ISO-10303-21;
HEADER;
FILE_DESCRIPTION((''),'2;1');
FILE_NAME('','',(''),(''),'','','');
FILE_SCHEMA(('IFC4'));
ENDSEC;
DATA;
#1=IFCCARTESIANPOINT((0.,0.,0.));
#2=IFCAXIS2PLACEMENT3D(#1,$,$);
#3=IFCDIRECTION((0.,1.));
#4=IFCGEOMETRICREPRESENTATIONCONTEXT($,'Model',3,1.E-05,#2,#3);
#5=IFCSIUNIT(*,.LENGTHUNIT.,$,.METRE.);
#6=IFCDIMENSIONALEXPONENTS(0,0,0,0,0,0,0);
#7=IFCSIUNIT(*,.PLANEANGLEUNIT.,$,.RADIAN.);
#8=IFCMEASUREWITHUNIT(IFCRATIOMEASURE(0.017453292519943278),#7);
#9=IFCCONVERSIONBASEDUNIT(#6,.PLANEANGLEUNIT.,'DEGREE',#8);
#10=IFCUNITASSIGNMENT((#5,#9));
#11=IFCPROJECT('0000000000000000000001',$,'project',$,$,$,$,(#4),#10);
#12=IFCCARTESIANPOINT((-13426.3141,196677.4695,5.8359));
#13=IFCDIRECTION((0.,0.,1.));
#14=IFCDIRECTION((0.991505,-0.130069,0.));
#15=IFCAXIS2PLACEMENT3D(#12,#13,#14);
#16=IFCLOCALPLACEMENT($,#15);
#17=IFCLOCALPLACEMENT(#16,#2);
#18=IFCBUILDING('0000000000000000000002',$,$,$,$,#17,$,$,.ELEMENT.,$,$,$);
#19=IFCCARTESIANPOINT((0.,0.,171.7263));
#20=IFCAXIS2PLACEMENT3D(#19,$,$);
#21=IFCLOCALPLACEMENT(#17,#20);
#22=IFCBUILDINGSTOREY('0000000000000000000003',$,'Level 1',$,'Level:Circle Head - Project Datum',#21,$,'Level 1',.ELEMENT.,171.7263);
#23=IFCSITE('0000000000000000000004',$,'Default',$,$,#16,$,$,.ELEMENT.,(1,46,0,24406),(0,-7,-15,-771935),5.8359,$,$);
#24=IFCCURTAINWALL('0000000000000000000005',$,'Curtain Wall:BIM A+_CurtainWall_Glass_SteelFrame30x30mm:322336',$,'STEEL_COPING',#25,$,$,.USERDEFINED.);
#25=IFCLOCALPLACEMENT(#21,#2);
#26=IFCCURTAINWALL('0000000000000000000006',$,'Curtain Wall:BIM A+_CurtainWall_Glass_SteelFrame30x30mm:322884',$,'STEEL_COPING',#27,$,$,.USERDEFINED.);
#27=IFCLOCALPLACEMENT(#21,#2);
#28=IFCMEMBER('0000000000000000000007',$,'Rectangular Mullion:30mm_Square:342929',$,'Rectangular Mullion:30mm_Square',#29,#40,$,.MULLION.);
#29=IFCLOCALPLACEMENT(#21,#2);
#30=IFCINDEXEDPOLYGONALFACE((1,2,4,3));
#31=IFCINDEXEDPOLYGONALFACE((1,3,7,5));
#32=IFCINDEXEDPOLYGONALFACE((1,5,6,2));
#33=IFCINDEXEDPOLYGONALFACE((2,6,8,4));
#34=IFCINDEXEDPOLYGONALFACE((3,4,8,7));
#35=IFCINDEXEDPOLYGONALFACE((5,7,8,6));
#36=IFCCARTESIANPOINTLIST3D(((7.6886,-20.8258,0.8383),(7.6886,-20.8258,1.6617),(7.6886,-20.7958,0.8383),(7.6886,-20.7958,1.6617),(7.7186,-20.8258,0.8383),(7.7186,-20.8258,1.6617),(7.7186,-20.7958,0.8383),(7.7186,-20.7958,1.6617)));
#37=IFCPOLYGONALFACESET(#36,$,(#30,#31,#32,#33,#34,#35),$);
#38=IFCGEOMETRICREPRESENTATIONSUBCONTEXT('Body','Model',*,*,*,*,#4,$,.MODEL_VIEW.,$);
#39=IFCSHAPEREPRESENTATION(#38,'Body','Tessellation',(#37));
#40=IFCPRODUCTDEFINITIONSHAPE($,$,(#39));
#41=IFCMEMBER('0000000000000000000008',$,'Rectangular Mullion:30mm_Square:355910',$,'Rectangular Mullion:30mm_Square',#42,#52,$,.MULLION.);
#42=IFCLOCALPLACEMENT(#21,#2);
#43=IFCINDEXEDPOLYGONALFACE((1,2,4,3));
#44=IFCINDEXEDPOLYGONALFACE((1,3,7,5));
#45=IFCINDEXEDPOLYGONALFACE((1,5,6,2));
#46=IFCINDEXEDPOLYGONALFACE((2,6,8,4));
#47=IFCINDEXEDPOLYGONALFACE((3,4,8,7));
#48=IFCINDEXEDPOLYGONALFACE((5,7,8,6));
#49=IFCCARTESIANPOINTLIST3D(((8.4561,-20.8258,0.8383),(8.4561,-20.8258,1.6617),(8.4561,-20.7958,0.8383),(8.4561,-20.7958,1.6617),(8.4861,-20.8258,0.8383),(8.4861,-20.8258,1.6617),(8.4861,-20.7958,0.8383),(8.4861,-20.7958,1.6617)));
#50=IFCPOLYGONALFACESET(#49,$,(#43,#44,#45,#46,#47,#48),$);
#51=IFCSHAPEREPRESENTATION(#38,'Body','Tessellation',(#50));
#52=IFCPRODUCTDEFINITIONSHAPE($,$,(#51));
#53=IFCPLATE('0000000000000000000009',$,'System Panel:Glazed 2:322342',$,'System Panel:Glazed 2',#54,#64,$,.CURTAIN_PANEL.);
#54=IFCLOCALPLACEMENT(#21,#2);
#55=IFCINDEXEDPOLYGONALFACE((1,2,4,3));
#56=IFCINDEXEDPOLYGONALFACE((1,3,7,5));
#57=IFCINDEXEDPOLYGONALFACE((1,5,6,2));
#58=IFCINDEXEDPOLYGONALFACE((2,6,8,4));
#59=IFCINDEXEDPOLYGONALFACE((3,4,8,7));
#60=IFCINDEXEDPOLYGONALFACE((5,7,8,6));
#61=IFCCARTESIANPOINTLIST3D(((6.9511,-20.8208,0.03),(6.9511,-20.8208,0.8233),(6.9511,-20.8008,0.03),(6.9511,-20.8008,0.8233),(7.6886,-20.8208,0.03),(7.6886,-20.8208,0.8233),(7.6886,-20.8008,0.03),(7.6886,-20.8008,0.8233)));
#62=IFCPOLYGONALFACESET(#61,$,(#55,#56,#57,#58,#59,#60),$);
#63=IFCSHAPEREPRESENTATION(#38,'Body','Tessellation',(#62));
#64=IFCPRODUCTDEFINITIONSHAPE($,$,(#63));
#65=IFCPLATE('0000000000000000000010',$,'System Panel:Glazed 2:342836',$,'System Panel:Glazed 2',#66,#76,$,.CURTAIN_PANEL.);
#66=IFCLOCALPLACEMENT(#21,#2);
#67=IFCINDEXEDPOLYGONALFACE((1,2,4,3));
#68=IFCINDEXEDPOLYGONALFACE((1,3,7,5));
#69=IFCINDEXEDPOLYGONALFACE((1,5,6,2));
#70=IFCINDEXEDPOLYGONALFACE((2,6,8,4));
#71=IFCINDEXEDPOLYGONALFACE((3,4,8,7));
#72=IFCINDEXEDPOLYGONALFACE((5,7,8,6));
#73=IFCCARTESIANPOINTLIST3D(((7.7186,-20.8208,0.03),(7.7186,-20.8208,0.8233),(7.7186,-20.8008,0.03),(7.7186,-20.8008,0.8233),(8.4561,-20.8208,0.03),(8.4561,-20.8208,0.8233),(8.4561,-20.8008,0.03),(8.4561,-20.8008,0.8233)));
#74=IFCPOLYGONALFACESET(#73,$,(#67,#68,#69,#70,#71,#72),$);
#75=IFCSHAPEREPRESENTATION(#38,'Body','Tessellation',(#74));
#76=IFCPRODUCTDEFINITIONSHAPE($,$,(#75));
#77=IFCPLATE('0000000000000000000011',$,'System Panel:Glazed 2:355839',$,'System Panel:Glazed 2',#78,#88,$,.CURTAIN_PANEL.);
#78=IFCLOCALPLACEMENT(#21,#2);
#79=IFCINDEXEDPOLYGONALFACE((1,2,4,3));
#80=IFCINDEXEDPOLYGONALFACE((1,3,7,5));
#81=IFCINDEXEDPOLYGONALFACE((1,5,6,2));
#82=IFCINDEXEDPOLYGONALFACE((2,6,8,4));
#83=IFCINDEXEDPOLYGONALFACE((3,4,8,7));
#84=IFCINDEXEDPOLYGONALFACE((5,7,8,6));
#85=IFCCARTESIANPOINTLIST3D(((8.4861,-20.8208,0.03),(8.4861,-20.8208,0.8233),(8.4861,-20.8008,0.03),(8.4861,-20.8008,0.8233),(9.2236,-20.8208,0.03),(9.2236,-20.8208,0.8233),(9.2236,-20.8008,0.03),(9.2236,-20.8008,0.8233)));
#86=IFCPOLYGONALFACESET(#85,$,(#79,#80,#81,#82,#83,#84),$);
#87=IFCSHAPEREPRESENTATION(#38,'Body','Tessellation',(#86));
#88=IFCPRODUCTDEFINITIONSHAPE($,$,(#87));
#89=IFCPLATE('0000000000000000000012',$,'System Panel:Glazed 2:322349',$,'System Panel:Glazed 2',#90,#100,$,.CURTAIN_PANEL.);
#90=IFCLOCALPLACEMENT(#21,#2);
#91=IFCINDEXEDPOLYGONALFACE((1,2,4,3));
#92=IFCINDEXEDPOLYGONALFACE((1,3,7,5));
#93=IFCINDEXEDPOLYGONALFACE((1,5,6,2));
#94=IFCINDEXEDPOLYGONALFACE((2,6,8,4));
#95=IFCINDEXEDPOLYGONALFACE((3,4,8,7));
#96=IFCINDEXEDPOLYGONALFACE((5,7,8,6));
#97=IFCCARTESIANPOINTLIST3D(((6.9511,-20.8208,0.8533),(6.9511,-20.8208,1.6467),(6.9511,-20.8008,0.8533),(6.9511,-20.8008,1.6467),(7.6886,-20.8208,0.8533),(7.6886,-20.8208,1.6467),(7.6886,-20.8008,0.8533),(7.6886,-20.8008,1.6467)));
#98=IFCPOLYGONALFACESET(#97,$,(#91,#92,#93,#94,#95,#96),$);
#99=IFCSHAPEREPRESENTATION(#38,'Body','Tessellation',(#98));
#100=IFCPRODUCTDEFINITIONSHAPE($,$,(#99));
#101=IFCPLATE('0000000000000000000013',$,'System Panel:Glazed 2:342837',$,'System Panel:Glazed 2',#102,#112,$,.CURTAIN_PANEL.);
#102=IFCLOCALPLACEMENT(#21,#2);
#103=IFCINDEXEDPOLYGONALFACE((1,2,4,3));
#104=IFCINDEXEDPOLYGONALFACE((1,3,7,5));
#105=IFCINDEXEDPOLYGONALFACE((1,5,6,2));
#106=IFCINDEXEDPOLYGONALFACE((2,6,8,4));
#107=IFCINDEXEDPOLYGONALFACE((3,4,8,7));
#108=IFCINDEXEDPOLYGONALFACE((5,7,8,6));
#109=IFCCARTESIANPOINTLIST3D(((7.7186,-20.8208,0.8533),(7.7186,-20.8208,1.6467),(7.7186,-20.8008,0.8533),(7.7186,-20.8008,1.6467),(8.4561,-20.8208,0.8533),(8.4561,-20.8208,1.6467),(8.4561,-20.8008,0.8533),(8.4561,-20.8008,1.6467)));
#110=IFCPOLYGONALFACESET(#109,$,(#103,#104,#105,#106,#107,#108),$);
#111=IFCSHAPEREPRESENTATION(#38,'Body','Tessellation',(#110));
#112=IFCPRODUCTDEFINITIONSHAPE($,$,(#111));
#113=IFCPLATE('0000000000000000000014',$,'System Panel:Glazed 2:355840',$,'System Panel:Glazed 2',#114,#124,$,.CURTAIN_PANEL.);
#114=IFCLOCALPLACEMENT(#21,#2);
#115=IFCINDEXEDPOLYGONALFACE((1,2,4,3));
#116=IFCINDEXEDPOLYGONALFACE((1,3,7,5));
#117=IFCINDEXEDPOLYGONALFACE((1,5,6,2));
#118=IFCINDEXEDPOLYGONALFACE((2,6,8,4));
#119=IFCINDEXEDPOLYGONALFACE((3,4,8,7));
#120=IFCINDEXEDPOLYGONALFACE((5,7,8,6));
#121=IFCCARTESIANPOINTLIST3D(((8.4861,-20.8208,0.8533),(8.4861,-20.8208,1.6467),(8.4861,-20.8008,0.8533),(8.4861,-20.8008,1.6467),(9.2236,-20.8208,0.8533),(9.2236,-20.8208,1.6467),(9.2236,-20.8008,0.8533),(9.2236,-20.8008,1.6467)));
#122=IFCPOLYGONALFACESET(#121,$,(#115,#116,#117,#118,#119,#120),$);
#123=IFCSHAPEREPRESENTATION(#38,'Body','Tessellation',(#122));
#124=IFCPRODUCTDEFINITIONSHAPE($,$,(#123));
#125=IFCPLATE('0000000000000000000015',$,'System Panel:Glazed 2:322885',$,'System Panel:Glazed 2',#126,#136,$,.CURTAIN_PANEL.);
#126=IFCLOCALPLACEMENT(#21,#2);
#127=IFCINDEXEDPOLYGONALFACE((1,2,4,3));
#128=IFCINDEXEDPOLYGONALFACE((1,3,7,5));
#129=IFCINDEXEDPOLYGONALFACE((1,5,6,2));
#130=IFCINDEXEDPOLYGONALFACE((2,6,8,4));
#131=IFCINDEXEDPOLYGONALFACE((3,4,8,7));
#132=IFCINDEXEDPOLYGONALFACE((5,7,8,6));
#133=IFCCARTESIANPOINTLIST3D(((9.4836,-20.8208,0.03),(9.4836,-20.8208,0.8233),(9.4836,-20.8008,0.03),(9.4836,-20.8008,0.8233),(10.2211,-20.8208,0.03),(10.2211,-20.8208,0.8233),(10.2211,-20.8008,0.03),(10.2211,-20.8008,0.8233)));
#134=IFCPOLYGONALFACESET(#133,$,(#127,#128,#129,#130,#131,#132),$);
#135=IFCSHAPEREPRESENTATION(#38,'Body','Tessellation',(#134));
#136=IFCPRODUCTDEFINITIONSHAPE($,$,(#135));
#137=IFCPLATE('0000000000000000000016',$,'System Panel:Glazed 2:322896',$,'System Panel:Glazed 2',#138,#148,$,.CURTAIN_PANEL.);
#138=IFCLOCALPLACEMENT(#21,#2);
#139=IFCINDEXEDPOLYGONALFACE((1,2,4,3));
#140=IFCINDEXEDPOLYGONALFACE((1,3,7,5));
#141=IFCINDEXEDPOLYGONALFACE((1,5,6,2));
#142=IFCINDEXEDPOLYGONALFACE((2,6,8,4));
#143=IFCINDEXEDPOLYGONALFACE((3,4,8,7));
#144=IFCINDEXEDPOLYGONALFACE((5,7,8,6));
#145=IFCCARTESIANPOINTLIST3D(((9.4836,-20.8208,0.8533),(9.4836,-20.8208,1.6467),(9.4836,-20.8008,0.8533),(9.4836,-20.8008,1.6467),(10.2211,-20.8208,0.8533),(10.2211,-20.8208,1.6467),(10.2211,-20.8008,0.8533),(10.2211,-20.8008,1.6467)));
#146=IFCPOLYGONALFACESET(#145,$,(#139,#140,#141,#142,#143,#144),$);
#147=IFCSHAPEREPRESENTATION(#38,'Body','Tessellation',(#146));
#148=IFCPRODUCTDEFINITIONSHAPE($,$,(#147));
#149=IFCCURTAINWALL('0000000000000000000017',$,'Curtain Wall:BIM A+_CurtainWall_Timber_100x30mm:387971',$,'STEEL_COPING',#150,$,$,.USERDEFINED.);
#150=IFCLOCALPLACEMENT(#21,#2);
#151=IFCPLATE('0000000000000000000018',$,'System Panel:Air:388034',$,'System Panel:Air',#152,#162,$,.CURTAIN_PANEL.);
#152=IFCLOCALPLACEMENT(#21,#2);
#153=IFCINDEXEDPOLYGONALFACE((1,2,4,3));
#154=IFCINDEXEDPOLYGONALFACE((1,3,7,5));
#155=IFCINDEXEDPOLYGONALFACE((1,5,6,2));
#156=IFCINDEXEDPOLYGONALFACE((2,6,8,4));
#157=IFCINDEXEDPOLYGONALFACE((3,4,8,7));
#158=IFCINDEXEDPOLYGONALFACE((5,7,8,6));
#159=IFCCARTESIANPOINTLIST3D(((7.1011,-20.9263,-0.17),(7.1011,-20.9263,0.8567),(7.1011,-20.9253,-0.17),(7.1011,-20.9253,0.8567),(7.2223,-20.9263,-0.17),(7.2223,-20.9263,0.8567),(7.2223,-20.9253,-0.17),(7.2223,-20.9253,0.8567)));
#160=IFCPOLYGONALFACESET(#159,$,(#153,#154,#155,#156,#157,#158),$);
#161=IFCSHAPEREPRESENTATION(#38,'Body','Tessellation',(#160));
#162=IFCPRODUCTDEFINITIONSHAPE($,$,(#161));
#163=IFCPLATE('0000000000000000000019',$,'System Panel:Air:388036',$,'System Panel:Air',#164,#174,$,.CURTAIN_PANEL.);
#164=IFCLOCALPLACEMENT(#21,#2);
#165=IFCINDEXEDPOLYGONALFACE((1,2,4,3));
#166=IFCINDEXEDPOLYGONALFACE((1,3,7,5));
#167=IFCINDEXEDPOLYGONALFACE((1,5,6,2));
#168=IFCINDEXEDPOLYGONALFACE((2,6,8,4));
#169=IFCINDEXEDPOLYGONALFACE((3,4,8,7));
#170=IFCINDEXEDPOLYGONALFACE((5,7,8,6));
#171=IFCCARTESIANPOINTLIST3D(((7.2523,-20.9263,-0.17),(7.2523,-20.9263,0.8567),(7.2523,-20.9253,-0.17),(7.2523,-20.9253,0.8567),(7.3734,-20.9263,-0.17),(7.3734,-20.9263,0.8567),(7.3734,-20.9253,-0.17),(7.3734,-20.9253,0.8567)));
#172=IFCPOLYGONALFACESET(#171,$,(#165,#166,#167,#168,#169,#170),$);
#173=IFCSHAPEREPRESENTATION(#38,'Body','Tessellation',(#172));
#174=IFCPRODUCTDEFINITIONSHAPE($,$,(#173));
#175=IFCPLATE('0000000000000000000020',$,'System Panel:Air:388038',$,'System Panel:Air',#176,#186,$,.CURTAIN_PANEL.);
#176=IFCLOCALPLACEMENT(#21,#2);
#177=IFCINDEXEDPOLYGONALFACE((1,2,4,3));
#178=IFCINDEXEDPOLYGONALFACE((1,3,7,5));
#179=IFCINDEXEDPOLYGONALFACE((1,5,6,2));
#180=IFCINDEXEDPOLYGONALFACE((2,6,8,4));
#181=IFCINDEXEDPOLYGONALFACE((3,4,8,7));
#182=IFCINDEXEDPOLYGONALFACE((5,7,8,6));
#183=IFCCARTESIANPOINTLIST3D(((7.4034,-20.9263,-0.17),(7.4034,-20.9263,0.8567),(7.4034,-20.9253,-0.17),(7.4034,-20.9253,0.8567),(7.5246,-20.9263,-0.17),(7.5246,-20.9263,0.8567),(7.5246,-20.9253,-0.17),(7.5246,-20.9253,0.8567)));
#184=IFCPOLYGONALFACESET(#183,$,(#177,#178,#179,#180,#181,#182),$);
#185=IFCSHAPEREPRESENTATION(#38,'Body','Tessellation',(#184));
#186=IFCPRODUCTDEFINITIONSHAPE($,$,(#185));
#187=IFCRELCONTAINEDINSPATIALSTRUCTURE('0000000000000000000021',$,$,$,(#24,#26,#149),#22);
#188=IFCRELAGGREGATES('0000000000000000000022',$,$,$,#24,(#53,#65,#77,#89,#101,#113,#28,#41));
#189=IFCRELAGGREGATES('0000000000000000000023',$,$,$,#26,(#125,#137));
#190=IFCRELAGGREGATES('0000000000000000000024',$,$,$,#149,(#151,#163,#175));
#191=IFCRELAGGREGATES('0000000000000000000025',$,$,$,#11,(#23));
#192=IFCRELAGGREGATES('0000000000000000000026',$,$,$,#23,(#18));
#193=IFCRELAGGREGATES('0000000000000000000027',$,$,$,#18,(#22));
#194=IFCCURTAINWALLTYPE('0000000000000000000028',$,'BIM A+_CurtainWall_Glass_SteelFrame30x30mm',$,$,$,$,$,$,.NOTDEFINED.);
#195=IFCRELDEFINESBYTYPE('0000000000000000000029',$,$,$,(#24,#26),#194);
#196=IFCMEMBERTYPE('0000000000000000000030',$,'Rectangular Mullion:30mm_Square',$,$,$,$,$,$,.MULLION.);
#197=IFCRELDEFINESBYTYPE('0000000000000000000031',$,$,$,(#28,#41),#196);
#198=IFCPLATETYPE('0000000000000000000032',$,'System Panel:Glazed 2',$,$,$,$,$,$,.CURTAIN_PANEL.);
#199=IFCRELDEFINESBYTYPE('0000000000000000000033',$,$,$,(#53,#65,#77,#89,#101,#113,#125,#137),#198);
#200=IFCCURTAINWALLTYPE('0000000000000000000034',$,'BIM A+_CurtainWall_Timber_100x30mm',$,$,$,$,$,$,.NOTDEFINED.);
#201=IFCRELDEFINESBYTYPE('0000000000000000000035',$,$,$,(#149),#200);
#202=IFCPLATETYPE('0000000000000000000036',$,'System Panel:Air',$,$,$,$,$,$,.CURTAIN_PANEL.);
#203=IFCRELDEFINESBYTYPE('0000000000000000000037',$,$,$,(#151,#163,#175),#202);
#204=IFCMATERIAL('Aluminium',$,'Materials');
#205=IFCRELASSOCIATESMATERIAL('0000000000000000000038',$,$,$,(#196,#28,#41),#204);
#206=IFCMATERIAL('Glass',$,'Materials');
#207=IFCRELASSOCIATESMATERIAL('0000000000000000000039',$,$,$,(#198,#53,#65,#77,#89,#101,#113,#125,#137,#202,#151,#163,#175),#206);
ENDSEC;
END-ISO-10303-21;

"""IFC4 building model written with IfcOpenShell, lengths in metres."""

from ifc_helpers import new_model, entity, si_unit, converted_unit, direction, frame, origin, place, context, subcontext, project, spatial, indexed_curve, outline, extrude, source, transform, mapped, material, type_object, type_shapes, element, aggregate, save


model = new_model("IFC4")

# Units and contexts
model_context = context("Model", 3, precision=1e-05, world=origin(), true_north=direction((0.0, 1.0)))
body_context = subcontext(model_context, "Body", "Model", "MODEL_VIEW")
ifc_project = project(units=[si_unit("LENGTHUNIT", "METRE"), converted_unit("PLANEANGLEUNIT", "DEGREE", entity("IfcRatioMeasure", 0.017453292519943278), si_unit("PLANEANGLEUNIT", "RADIAN"), dimensions=[0, 0, 0, 0, 0, 0, 0])], contexts=[model_context])

# Site, building, storey
site_placement = place(None, frame((-13426.3141, 196677.4695, 5.8359), z_axis=(0.0, 0.0, 1.0), x_axis=(0.991505, -0.130069, 0.0)))
site = spatial("IfcSite", under=ifc_project, at=site_placement, Name="Default", CompositionType="ELEMENT", RefLatitude=(1, 46, 0, 24406), RefLongitude=(0, -7, -15, -771935), RefElevation=5.8359)
building_placement = place(site_placement, origin())
building = spatial("IfcBuilding", under=site, at=building_placement, CompositionType="ELEMENT")
storey_placement = place(building_placement, frame((0.0, 0.0, 171.7263)))
storey = spatial("IfcBuildingStorey", under=building, at=storey_placement, Name="Level 1", ObjectType="Level:Circle Head - Project Datum", LongName="Level 1", CompositionType="ELEMENT", Elevation=171.7263)

# Curtain wall
curtain_wall_type_1 = type_object("IfcCurtainWallType", Name="BIM A+_CurtainWall_Glass_SteelFrame30x30mm", PredefinedType="NOTDEFINED")
curtain_wall_1_placement = place(storey_placement, frame((0.0, 0.0, -171.7263)))
curtain_wall_1 = element("IfcCurtainWall", 1, at=curtain_wall_1_placement, inside=storey, type_object=curtain_wall_type_1, Name="Curtain Wall:BIM A+_CurtainWall_Glass_SteelFrame30x30mm:322336", ObjectType="STEEL_COPING", PredefinedType="USERDEFINED")
ifc_material_1 = material(Name="Aluminium", Category="Materials")

# Curtain wall
curtain_wall_2_placement = place(storey_placement, frame((0.0, 0.0, -171.7263)))
curtain_wall_2 = element("IfcCurtainWall", 2, at=curtain_wall_2_placement, inside=storey, type_object=curtain_wall_type_1, Name="Curtain Wall:BIM A+_CurtainWall_Glass_SteelFrame30x30mm:322884", ObjectType="STEEL_COPING", PredefinedType="USERDEFINED")

# Members
member_type_1 = type_object("IfcMemberType", Name="Rectangular Mullion:30mm_Square", PredefinedType="MULLION", material=ifc_material_1)
shared_shape_1 = source(origin(), body_context, "Body", "SweptSolid", [
    extrude(outline(indexed_curve([(-0.015, -0.015), (0.015, -0.015), (0.015, 0.015), (-0.015, 0.015), (-0.015, -0.015)], self_intersect=False)), frame((0.0, 0.0, -0.8233), z_axis=(0.0, 0.0, 1.0), x_axis=(0.0, -1.0, 0.0)), (0.0, 0.0, 1.0), 0.8233),
])
type_shapes(member_type_1, [shared_shape_1])
member_1_placement = place(curtain_wall_1_placement, frame((7.7036, -20.8108, 172.5646), z_axis=(0.0, 0.0, -1.0), x_axis=(1.0, 0.0, 0.0)))
member_1 = element("IfcMember", 3, at=member_1_placement, type_object=member_type_1, material=ifc_material_1, Name="Rectangular Mullion:30mm_Square:342929", ObjectType="Rectangular Mullion:30mm_Square", PredefinedType="MULLION", context=body_context, shape_type="MappedRepresentation", body=[
    mapped(shared_shape_1, transform((0.0, 0.0, 0.0), scale=1.0)),
])
member_2_placement = place(curtain_wall_1_placement, frame((8.4711, -20.8108, 172.5646), z_axis=(0.0, 0.0, -1.0), x_axis=(1.0, 0.0, 0.0)))
member_2 = element("IfcMember", 4, at=member_2_placement, type_object=member_type_1, material=ifc_material_1, Name="Rectangular Mullion:30mm_Square:355910", ObjectType="Rectangular Mullion:30mm_Square", PredefinedType="MULLION", context=body_context, shape_type="MappedRepresentation", body=[
    mapped(shared_shape_1, transform((0.0, 0.0, 0.0), scale=1.0)),
])

# Plates
ifc_material_2 = material(Name="Glass", Category="Materials")
plate_type_1 = type_object("IfcPlateType", Name="System Panel:Glazed 2", PredefinedType="CURTAIN_PANEL", material=ifc_material_2)
shared_shape_2 = source(origin(), body_context, "Body", "SweptSolid", [
    extrude(outline(indexed_curve([(-0.01, -0.3688), (0.01, -0.3688), (0.01, 0.3688), (-0.01, 0.3688), (-0.01, -0.3688)], self_intersect=False)), frame((0.0, 0.0, 0.0), z_axis=(0.0, 0.0, 1.0), x_axis=(0.0, 1.0, 0.0)), (0.0, 0.0, 1.0), 0.7933),
])
type_shapes(plate_type_1, [shared_shape_2])
plate_1_placement = place(curtain_wall_1_placement, frame((7.3198, -20.8108, 171.7563)))
plate_1 = element("IfcPlate", 5, at=plate_1_placement, type_object=plate_type_1, material=ifc_material_2, Name="System Panel:Glazed 2:322342", ObjectType="System Panel:Glazed 2", PredefinedType="CURTAIN_PANEL", context=body_context, shape_type="MappedRepresentation", body=[
    mapped(shared_shape_2, transform((0.0, 0.0, 0.0), scale=1.0)),
])
plate_2_placement = place(curtain_wall_1_placement, frame((8.0873, -20.8108, 171.7563)))
plate_2 = element("IfcPlate", 6, at=plate_2_placement, type_object=plate_type_1, material=ifc_material_2, Name="System Panel:Glazed 2:342836", ObjectType="System Panel:Glazed 2", PredefinedType="CURTAIN_PANEL", context=body_context, shape_type="MappedRepresentation", body=[
    mapped(shared_shape_2, transform((0.0, 0.0, 0.0), scale=1.0)),
])
plate_3_placement = place(curtain_wall_1_placement, frame((8.8548, -20.8108, 171.7563)))
plate_3 = element("IfcPlate", 7, at=plate_3_placement, type_object=plate_type_1, material=ifc_material_2, Name="System Panel:Glazed 2:355839", ObjectType="System Panel:Glazed 2", PredefinedType="CURTAIN_PANEL", context=body_context, shape_type="MappedRepresentation", body=[
    mapped(shared_shape_2, transform((0.0, 0.0, 0.0), scale=1.0)),
])
plate_4_placement = place(curtain_wall_1_placement, frame((7.3198, -20.8108, 172.5796)))
plate_4 = element("IfcPlate", 8, at=plate_4_placement, type_object=plate_type_1, material=ifc_material_2, Name="System Panel:Glazed 2:322349", ObjectType="System Panel:Glazed 2", PredefinedType="CURTAIN_PANEL", context=body_context, shape_type="MappedRepresentation", body=[
    mapped(shared_shape_2, transform((0.0, 0.0, 0.0), scale=1.0)),
])
plate_5_placement = place(curtain_wall_1_placement, frame((8.0873, -20.8108, 172.5796)))
plate_5 = element("IfcPlate", 9, at=plate_5_placement, type_object=plate_type_1, material=ifc_material_2, Name="System Panel:Glazed 2:342837", ObjectType="System Panel:Glazed 2", PredefinedType="CURTAIN_PANEL", context=body_context, shape_type="MappedRepresentation", body=[
    mapped(shared_shape_2, transform((0.0, 0.0, 0.0), scale=1.0)),
])
plate_6_placement = place(curtain_wall_1_placement, frame((8.8548, -20.8108, 172.5796)))
plate_6 = element("IfcPlate", 10, at=plate_6_placement, type_object=plate_type_1, material=ifc_material_2, Name="System Panel:Glazed 2:355840", ObjectType="System Panel:Glazed 2", PredefinedType="CURTAIN_PANEL", context=body_context, shape_type="MappedRepresentation", body=[
    mapped(shared_shape_2, transform((0.0, 0.0, 0.0), scale=1.0)),
])
aggregate(curtain_wall_1, [plate_1, plate_2, plate_3, plate_4, plate_5, plate_6, member_1, member_2])
plate_7_placement = place(curtain_wall_2_placement, frame((9.8523, -20.8108, 171.7563)))
plate_7 = element("IfcPlate", 11, at=plate_7_placement, type_object=plate_type_1, material=ifc_material_2, Name="System Panel:Glazed 2:322885", ObjectType="System Panel:Glazed 2", PredefinedType="CURTAIN_PANEL", context=body_context, shape_type="MappedRepresentation", body=[
    mapped(shared_shape_2, transform((0.0, 0.0, 0.0), scale=1.0)),
])
plate_8_placement = place(curtain_wall_2_placement, frame((9.8523, -20.8108, 172.5796)))
plate_8 = element("IfcPlate", 12, at=plate_8_placement, type_object=plate_type_1, material=ifc_material_2, Name="System Panel:Glazed 2:322896", ObjectType="System Panel:Glazed 2", PredefinedType="CURTAIN_PANEL", context=body_context, shape_type="MappedRepresentation", body=[
    mapped(shared_shape_2, transform((0.0, 0.0, 0.0), scale=1.0)),
])
aggregate(curtain_wall_2, [plate_7, plate_8])

# Curtain wall, plates
curtain_wall_type_2 = type_object("IfcCurtainWallType", Name="BIM A+_CurtainWall_Timber_100x30mm", PredefinedType="NOTDEFINED")
curtain_wall_3_placement = place(storey_placement, frame((0.0, 0.0, -171.7263)))
curtain_wall_3 = element("IfcCurtainWall", 13, at=curtain_wall_3_placement, inside=storey, type_object=curtain_wall_type_2, Name="Curtain Wall:BIM A+_CurtainWall_Timber_100x30mm:387971", ObjectType="STEEL_COPING", PredefinedType="USERDEFINED")
plate_type_2 = type_object("IfcPlateType", Name="System Panel:Air", PredefinedType="CURTAIN_PANEL", material=ifc_material_2)
shared_shape_3 = source(origin(), body_context, "Body", "SweptSolid", [
    extrude(outline(indexed_curve([(-0.0005, -0.0606), (0.0005, -0.0606), (0.0005, 0.0606), (-0.0005, 0.0606), (-0.0005, -0.0606)], self_intersect=False)), frame((0.0, 0.0, 0.0), z_axis=(0.0, 0.0, 1.0), x_axis=(0.0, 1.0, 0.0)), (0.0, 0.0, 1.0), 1.0267),
])
type_shapes(plate_type_2, [shared_shape_3])
plate_9_placement = place(curtain_wall_3_placement, frame((7.1617, -20.9258, 171.5563)))
plate_9 = element("IfcPlate", 14, at=plate_9_placement, type_object=plate_type_2, material=ifc_material_2, Name="System Panel:Air:388034", ObjectType="System Panel:Air", PredefinedType="CURTAIN_PANEL", context=body_context, shape_type="MappedRepresentation", body=[
    mapped(shared_shape_3, transform((0.0, 0.0, 0.0), scale=1.0)),
])
plate_10_placement = place(curtain_wall_3_placement, frame((7.3129, -20.9258, 171.5563)))
plate_10 = element("IfcPlate", 15, at=plate_10_placement, type_object=plate_type_2, material=ifc_material_2, Name="System Panel:Air:388036", ObjectType="System Panel:Air", PredefinedType="CURTAIN_PANEL", context=body_context, shape_type="MappedRepresentation", body=[
    mapped(shared_shape_3, transform((0.0, 0.0, 0.0), scale=1.0)),
])
plate_11_placement = place(curtain_wall_3_placement, frame((7.464, -20.9258, 171.5563)))
plate_11 = element("IfcPlate", 16, at=plate_11_placement, type_object=plate_type_2, material=ifc_material_2, Name="System Panel:Air:388038", ObjectType="System Panel:Air", PredefinedType="CURTAIN_PANEL", context=body_context, shape_type="MappedRepresentation", body=[
    mapped(shared_shape_3, transform((0.0, 0.0, 0.0), scale=1.0)),
])
aggregate(curtain_wall_3, [plate_9, plate_10, plate_11])

save(model, "model.ifc")
